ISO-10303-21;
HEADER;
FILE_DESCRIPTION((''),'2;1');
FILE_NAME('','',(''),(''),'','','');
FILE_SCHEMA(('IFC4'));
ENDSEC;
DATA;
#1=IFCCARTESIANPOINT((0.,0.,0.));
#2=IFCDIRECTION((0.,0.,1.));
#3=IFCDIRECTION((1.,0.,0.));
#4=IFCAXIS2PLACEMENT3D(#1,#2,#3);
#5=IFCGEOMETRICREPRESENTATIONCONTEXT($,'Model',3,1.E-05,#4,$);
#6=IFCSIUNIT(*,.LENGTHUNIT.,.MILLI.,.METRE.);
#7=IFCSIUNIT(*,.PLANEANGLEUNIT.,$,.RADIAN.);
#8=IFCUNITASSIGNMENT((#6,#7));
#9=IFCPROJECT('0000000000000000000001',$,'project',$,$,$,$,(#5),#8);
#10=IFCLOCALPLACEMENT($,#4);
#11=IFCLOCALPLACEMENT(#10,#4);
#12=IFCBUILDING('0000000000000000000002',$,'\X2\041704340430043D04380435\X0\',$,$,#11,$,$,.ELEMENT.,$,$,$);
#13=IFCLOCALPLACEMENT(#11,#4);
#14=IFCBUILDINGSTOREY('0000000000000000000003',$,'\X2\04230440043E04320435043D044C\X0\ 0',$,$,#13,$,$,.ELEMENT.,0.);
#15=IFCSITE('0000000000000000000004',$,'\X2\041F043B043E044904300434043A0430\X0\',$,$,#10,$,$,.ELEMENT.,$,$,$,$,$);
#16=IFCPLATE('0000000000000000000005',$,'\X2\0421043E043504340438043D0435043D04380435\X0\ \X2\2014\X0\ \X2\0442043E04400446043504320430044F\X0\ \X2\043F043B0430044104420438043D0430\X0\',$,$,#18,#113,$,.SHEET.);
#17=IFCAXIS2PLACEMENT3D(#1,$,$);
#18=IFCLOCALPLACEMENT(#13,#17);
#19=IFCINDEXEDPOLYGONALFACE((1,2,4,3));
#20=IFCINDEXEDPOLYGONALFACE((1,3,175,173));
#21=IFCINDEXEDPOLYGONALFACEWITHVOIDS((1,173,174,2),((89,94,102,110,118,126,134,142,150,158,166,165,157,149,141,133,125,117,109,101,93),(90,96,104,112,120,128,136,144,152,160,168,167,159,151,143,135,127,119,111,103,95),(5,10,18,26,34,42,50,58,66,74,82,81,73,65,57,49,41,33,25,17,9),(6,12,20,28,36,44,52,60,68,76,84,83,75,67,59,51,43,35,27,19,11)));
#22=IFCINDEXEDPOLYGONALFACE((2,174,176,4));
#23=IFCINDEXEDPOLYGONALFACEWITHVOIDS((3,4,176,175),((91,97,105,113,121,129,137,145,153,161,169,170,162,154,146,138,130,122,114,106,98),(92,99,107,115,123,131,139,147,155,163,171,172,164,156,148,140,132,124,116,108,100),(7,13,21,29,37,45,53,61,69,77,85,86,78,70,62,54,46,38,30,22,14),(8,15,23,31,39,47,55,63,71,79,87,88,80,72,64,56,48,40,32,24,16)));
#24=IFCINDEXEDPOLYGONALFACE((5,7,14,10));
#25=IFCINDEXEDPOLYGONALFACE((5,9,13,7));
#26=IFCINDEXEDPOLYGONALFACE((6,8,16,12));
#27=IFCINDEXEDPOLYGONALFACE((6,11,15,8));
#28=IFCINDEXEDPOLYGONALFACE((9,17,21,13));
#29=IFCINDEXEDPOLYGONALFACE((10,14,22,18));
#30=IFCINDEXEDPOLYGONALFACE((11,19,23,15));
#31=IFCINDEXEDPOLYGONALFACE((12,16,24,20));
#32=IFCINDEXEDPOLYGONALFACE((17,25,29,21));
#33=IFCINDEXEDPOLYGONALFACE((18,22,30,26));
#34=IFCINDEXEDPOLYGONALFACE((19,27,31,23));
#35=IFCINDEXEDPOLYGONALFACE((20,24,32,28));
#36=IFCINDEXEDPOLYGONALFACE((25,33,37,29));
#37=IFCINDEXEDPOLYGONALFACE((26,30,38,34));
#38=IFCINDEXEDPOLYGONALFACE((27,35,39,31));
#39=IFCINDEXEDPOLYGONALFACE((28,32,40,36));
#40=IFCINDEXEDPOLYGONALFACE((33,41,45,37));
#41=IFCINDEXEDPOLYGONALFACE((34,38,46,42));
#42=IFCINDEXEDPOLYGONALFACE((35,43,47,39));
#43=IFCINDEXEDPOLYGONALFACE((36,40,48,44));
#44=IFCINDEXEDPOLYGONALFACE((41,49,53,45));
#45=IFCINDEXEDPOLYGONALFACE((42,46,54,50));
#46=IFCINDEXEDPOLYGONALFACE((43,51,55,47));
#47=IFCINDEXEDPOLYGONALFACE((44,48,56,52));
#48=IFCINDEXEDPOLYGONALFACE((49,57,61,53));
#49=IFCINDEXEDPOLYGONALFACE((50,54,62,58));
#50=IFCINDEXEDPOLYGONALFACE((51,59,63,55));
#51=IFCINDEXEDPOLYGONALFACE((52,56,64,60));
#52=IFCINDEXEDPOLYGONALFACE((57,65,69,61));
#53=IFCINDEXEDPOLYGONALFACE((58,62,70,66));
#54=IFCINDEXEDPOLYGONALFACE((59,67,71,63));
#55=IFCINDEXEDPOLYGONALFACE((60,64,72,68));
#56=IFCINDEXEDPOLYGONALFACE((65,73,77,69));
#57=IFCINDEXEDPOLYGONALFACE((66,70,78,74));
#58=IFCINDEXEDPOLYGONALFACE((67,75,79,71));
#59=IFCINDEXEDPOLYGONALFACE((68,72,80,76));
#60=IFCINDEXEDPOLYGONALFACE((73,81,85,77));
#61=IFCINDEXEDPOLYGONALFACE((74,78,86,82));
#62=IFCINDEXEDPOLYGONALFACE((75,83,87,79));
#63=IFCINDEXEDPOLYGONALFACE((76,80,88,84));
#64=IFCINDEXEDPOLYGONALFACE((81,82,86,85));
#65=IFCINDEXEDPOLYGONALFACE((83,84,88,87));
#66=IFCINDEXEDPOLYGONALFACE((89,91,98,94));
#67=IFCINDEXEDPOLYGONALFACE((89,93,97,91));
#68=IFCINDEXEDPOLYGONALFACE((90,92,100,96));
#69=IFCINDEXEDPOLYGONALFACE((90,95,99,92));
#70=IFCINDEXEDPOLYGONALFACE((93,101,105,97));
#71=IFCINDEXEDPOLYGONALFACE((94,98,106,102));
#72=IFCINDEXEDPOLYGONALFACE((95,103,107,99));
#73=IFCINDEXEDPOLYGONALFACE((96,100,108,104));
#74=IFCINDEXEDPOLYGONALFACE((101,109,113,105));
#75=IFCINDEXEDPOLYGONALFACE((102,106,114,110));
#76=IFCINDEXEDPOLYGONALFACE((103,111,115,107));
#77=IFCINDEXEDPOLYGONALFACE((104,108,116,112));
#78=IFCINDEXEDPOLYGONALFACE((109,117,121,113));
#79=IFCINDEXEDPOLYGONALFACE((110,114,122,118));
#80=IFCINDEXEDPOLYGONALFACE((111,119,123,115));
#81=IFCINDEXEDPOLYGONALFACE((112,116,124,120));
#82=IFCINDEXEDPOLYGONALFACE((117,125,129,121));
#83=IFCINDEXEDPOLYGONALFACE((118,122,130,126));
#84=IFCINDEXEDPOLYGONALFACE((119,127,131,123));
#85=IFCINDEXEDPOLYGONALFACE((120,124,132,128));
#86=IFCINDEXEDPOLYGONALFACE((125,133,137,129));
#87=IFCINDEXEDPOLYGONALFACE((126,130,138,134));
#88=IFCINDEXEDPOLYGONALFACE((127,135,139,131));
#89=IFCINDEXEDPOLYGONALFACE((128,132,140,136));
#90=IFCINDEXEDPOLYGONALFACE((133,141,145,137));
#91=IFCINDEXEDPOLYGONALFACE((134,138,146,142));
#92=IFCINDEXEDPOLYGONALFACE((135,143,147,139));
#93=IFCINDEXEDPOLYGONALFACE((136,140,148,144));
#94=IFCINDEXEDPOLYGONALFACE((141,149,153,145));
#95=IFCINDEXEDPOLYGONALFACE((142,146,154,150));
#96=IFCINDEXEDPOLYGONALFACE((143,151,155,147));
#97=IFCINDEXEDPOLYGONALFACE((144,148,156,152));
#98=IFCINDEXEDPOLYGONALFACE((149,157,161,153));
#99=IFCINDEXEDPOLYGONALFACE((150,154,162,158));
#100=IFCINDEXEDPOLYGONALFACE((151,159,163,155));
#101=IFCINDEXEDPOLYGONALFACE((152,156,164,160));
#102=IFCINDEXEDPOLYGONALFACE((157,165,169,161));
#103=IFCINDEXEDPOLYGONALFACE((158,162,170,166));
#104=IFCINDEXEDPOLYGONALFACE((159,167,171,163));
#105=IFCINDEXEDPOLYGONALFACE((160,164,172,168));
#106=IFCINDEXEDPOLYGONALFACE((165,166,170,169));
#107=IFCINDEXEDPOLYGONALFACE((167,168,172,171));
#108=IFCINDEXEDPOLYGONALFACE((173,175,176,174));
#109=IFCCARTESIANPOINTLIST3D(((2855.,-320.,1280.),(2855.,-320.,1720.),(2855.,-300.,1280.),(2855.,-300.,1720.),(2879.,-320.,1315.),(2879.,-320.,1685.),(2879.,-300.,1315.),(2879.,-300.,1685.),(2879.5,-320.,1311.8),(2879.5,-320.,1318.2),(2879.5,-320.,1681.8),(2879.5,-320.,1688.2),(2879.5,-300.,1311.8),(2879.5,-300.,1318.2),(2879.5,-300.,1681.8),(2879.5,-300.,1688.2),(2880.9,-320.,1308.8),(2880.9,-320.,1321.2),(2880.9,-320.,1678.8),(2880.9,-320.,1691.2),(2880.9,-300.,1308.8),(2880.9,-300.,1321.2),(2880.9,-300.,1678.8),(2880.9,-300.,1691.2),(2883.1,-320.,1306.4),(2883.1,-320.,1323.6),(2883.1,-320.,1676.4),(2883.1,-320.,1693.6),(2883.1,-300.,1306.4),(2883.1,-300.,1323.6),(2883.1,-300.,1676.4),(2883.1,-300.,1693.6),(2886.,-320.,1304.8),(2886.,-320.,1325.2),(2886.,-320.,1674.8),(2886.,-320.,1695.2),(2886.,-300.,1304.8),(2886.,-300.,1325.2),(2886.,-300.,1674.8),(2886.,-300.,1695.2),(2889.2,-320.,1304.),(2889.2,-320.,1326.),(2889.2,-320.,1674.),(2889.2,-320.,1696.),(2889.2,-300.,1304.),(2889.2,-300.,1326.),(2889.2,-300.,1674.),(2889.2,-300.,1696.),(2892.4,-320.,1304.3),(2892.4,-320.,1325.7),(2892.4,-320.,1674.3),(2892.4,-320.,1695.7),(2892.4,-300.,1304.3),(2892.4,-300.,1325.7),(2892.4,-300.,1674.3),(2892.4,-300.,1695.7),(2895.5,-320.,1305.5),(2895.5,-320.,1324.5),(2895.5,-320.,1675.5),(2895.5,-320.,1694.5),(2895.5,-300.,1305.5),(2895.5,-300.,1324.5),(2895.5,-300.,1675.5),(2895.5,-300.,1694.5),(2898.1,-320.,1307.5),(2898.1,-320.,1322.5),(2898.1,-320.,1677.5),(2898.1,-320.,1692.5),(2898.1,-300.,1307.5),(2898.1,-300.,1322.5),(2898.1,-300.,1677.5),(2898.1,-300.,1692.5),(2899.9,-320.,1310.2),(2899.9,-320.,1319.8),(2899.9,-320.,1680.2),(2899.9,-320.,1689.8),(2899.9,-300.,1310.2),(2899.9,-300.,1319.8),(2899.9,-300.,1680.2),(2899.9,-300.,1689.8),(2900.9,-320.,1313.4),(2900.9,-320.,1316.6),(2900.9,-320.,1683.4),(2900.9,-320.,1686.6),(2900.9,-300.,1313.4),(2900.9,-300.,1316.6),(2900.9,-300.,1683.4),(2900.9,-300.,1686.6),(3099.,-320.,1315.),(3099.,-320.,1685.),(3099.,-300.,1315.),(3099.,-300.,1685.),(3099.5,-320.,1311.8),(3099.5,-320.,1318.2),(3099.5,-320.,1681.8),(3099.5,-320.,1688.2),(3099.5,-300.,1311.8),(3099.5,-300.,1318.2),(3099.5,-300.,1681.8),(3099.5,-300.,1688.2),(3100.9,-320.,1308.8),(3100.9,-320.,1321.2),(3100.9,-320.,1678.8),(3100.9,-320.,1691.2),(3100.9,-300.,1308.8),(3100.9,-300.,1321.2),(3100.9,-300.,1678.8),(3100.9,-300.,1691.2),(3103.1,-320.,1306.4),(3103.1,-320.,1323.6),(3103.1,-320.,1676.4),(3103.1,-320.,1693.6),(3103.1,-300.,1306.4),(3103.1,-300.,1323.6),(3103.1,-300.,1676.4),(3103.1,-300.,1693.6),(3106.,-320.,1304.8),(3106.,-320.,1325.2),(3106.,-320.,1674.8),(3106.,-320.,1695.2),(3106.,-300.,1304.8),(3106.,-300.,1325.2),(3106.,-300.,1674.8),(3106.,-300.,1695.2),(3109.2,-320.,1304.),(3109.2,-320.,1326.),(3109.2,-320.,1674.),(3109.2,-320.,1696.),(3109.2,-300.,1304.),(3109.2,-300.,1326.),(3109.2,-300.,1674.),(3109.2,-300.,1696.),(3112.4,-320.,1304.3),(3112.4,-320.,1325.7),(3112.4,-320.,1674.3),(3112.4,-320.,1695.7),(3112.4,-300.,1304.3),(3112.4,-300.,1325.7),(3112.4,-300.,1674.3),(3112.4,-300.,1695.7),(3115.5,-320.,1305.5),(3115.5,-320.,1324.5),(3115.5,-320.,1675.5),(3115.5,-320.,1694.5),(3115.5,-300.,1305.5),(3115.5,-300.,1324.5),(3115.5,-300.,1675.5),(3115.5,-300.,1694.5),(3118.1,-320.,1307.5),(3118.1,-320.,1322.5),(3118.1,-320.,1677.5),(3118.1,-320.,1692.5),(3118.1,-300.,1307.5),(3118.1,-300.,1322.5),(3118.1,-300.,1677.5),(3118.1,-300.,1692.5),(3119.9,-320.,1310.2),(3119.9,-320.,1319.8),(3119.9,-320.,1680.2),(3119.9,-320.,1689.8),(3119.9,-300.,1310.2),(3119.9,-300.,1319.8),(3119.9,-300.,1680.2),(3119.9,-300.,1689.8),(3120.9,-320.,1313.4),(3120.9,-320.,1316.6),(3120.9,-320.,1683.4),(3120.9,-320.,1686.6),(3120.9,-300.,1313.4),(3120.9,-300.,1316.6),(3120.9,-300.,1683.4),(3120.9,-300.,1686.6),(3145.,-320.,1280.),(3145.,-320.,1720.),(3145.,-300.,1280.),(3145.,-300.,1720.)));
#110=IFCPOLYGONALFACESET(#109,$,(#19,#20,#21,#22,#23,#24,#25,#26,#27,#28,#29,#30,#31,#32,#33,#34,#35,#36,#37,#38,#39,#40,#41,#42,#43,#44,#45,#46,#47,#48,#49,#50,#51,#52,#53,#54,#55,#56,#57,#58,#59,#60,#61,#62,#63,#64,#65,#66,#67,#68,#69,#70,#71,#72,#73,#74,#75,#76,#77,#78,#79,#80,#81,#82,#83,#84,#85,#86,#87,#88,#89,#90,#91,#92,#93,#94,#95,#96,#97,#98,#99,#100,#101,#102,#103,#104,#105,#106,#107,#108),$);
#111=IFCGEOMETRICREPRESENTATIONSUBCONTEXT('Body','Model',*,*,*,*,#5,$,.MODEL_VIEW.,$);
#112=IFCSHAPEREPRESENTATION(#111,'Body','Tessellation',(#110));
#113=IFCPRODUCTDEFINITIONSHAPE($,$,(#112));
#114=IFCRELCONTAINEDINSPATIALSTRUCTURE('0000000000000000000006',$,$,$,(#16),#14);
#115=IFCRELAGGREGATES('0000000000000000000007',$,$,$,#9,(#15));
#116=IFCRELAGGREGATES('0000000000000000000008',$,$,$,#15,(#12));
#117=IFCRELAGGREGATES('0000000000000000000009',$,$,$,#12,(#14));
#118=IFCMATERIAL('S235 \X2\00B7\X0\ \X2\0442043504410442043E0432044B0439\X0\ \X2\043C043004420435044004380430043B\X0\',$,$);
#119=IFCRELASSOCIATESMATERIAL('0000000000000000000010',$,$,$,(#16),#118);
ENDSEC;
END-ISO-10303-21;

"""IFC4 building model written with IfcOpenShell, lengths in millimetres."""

from ifc_helpers import new_model, si_unit, frame, origin_with_axes, place, context, subcontext, project, spatial, polyline, circle, outline, extrude, material, element, save


model = new_model("IFC4")

# Units and contexts
model_context = context("Model", 3, precision=1e-05, world=origin_with_axes())
body_context = subcontext(model_context, "Body", "Model", "MODEL_VIEW")
ifc_project = project(units=[si_unit("LENGTHUNIT", "METRE", prefix="MILLI"), si_unit("PLANEANGLEUNIT", "RADIAN")], contexts=[model_context])

# Site, building, storey
site_placement = place(None, origin_with_axes())
site = spatial("IfcSite", under=ifc_project, at=site_placement, Name="Площадка", CompositionType="ELEMENT")
building_placement = place(site_placement, origin_with_axes())
building = spatial("IfcBuilding", under=site, at=building_placement, Name="Здание", CompositionType="ELEMENT")
storey_placement = place(building_placement, origin_with_axes())
storey = spatial("IfcBuildingStorey", under=building, at=storey_placement, Name="Уровень 0", CompositionType="ELEMENT", Elevation=0.0)

# Shared definitions
ifc_material = material(Name="S235 · тестовый материал")

# Plate, openings
plate_1_placement = place(storey_placement, frame((3145.0, -320.0, 1280.0), z_axis=(0.0, 1.0, 0.0), x_axis=(-1.0, 0.0, 0.0)))
plate_1 = element("IfcPlate", 1, at=plate_1_placement, inside=storey, material=ifc_material, Name="Соединение — торцевая пластина", PredefinedType="SHEET", context=body_context, shape_type="SweptSolid", body=[
    extrude(outline(polyline([(0.0, 0.0), (290.0, 0.0), (290.0, 440.0), (0.0, 440.0), (0.0, 0.0)])), origin_with_axes(), (0.0, 0.0, 1.0), 20.0),
])
opening_1_placement = place(plate_1_placement, frame((35.0, 35.0, -1.0), z_axis=(0.0, 0.0, 1.0), x_axis=(1.0, 0.0, 0.0)))
element("IfcOpeningElement", 2, at=opening_1_placement, cuts=plate_1, PredefinedType="OPENING", context=body_context, shape_type="SweptSolid", body=[
    extrude(circle(Radius=11.0), origin_with_axes(), (0.0, 0.0, 1.0), 42.0),
])
opening_2_placement = place(plate_1_placement, frame((35.0, 405.0, -1.0), z_axis=(0.0, 0.0, 1.0), x_axis=(1.0, 0.0, 0.0)))
element("IfcOpeningElement", 3, at=opening_2_placement, cuts=plate_1, PredefinedType="OPENING", context=body_context, shape_type="SweptSolid", body=[
    extrude(circle(Radius=11.0), origin_with_axes(), (0.0, 0.0, 1.0), 42.0),
])
opening_3_placement = place(plate_1_placement, frame((255.0, 35.0, -1.0), z_axis=(0.0, 0.0, 1.0), x_axis=(1.0, 0.0, 0.0)))
element("IfcOpeningElement", 4, at=opening_3_placement, cuts=plate_1, PredefinedType="OPENING", context=body_context, shape_type="SweptSolid", body=[
    extrude(circle(Radius=11.0), origin_with_axes(), (0.0, 0.0, 1.0), 42.0),
])
opening_4_placement = place(plate_1_placement, frame((255.0, 405.0, -1.0), z_axis=(0.0, 0.0, 1.0), x_axis=(1.0, 0.0, 0.0)))
element("IfcOpeningElement", 5, at=opening_4_placement, cuts=plate_1, PredefinedType="OPENING", context=body_context, shape_type="SweptSolid", body=[
    extrude(circle(Radius=11.0), origin_with_axes(), (0.0, 0.0, 1.0), 42.0),
])

save(model, "model.ifc")
